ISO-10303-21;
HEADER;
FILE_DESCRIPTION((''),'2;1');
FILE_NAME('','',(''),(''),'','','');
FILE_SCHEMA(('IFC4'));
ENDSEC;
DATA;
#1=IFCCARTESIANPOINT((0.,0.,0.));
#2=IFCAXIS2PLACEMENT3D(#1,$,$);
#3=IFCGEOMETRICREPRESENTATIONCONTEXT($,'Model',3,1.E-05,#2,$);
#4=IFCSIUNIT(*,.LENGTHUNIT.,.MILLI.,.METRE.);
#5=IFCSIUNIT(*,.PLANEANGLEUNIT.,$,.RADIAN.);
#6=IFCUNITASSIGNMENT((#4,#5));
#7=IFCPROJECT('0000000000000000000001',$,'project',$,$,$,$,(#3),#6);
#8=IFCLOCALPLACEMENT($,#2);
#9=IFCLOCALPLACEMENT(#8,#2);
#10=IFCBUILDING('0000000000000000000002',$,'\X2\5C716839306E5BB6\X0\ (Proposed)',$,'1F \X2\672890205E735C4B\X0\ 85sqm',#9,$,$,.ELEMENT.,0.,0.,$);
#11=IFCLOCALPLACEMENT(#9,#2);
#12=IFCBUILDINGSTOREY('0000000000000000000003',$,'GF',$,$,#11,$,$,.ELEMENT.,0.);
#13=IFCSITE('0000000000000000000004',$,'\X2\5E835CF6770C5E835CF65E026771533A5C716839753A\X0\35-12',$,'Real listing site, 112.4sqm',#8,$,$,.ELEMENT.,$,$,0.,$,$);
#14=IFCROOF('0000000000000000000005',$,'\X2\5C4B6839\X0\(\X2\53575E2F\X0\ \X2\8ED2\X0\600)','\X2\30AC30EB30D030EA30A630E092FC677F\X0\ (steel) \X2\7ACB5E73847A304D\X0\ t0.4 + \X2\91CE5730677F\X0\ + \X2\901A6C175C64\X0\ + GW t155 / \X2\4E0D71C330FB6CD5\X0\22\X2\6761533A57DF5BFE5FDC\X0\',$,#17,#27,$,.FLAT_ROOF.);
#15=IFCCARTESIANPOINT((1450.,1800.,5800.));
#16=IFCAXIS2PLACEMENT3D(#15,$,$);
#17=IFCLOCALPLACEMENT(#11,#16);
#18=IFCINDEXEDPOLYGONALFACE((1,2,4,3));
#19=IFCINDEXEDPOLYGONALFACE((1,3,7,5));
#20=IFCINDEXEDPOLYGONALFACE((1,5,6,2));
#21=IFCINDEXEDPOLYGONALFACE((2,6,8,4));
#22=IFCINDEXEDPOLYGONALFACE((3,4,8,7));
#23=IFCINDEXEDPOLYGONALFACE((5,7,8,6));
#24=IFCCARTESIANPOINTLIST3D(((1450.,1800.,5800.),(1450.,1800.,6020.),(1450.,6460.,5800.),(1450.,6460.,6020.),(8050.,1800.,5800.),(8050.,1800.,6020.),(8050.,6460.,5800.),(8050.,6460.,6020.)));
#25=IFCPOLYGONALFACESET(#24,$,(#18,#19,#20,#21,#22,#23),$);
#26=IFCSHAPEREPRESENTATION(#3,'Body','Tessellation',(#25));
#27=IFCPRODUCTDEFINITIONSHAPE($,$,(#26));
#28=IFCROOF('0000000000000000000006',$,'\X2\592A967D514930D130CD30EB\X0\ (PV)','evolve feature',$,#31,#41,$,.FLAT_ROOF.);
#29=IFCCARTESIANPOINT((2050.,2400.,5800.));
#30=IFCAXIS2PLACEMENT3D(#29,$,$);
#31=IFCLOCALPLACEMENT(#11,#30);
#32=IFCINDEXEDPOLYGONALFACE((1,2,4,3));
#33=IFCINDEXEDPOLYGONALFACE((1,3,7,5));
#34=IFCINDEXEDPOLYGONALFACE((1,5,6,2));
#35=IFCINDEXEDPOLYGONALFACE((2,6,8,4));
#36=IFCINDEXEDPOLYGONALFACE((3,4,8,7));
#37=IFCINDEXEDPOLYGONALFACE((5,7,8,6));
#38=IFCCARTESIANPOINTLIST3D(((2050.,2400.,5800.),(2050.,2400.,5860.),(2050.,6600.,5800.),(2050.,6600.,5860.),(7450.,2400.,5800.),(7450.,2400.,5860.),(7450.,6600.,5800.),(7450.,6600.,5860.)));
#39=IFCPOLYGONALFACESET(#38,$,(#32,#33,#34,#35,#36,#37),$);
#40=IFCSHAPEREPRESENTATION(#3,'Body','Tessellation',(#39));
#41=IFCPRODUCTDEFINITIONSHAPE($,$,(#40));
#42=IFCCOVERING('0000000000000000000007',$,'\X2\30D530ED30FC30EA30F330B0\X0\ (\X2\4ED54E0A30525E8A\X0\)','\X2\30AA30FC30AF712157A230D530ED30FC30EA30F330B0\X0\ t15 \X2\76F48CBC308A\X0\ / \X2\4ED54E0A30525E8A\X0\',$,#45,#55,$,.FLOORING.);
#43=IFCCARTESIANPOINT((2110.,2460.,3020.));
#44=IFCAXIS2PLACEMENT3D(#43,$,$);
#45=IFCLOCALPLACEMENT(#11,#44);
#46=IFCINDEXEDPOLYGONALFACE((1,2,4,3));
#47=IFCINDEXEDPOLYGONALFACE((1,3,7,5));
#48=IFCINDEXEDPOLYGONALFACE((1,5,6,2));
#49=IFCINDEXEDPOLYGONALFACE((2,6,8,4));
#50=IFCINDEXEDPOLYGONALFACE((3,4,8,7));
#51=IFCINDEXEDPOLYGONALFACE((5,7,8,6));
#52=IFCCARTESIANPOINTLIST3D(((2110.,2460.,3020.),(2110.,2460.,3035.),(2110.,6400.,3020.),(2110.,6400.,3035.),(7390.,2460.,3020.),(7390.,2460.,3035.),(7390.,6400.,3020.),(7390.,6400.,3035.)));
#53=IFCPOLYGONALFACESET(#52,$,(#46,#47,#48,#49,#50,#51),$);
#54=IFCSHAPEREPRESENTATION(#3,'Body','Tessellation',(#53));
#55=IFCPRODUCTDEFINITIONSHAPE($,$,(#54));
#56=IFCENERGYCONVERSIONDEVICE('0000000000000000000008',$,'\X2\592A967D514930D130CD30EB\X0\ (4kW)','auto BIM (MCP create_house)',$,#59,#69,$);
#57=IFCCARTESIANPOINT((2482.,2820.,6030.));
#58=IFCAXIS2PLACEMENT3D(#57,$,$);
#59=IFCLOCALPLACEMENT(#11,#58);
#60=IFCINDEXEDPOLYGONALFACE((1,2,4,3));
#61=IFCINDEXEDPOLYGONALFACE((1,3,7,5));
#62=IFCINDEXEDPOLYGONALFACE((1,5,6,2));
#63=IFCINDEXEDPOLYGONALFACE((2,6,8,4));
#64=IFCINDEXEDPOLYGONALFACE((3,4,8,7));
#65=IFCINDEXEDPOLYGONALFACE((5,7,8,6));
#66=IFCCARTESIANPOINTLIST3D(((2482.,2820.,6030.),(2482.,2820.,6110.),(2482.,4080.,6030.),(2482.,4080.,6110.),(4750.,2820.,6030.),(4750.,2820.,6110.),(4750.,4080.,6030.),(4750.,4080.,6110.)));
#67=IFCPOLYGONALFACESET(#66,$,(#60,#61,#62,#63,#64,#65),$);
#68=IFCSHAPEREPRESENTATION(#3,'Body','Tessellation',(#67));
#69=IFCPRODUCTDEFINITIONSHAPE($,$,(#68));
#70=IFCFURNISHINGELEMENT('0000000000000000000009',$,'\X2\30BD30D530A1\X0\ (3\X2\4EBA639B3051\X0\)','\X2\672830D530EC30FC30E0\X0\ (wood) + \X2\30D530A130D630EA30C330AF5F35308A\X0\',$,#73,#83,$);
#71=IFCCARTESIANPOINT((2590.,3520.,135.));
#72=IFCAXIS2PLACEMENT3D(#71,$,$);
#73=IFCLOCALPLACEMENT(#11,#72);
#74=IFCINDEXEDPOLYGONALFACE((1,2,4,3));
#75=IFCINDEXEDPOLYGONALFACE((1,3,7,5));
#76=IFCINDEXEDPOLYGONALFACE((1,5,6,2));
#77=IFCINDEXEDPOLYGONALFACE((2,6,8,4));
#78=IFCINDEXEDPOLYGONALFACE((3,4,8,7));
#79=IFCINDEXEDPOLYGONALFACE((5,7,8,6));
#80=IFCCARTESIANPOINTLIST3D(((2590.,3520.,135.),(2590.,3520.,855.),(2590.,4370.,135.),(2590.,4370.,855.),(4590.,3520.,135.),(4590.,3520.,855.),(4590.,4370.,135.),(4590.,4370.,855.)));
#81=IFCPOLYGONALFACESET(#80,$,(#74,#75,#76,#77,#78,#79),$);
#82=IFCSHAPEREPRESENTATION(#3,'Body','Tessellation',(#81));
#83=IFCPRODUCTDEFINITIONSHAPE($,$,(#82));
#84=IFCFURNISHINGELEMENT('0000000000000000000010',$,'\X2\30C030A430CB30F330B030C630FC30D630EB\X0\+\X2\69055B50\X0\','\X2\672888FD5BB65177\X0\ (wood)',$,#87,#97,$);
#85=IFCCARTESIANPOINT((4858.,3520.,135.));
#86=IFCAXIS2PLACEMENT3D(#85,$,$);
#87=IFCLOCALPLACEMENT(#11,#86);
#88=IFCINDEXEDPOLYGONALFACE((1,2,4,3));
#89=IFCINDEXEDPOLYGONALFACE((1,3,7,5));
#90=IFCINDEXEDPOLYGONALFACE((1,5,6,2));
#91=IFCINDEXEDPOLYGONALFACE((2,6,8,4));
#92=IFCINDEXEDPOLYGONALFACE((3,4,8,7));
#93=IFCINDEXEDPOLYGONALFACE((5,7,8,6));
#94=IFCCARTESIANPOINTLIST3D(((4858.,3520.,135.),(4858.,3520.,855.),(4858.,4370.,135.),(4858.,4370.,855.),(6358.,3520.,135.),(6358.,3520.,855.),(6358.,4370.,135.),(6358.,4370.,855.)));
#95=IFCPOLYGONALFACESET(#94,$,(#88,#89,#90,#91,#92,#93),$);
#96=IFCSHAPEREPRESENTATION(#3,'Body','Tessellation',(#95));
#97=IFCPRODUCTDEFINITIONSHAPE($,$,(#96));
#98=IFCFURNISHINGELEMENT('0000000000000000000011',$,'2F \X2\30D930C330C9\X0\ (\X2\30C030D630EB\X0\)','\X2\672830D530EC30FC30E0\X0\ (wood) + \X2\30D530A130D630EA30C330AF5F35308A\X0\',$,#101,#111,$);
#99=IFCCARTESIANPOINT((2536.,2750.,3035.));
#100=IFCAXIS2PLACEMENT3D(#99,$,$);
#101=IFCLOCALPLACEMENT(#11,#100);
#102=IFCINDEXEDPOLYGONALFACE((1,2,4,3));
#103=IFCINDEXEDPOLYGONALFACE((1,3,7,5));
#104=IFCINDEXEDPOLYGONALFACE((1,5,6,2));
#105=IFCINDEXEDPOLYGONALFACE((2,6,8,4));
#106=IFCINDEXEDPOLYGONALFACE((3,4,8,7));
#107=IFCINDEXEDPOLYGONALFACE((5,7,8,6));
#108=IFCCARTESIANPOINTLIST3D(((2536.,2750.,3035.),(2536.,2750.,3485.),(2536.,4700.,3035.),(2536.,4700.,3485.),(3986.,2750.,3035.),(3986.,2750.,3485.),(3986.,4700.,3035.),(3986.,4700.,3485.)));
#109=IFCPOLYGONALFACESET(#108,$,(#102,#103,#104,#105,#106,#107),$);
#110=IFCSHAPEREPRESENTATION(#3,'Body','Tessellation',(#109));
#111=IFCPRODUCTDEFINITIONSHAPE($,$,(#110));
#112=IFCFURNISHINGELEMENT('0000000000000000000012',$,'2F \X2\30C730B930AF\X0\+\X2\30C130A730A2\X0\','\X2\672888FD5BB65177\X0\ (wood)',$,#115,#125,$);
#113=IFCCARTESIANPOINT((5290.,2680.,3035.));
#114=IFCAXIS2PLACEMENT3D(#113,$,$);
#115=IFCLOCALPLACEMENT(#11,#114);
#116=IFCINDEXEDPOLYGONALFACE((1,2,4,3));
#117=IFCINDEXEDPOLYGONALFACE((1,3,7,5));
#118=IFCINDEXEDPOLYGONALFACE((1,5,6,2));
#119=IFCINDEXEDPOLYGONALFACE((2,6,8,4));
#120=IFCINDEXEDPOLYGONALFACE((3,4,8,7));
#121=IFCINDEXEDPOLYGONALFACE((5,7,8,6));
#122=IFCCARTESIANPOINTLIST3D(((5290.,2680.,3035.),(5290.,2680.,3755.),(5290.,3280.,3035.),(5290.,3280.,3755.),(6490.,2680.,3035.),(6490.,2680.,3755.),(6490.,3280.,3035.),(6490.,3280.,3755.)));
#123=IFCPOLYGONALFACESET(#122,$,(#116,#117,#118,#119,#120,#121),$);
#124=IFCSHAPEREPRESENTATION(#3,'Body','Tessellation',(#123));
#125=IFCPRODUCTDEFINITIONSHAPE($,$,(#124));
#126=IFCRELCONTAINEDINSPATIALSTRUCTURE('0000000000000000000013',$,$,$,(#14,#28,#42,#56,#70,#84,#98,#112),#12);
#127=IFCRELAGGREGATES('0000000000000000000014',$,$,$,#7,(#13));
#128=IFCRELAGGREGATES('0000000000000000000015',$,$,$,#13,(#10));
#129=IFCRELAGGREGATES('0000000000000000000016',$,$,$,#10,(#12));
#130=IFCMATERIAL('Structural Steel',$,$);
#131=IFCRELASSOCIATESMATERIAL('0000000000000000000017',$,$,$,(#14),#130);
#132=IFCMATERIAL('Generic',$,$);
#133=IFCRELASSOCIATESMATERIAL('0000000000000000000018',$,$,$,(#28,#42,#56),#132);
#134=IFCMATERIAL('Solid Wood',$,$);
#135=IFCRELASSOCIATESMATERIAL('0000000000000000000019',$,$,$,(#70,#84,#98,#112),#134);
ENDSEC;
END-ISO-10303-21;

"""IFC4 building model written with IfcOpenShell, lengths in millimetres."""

from ifc_helpers import new_model, si_unit, frame, frame_2d, origin, place, context, project, spatial, rectangle, extrude, material, element, save


model = new_model("IFC4")

# Units and contexts
model_context = context("Model", 3, precision=1e-05, world=origin())
ifc_project = project(units=[si_unit("LENGTHUNIT", "METRE", prefix="MILLI"), si_unit("PLANEANGLEUNIT", "RADIAN")], contexts=[model_context])

# Site, building, storey
site_placement = place(None, origin())
site = spatial("IfcSite", under=ifc_project, at=site_placement, Name="広島県広島市東区山根町35-12", ObjectType="Real listing site, 112.4sqm", CompositionType="ELEMENT", RefElevation=0.0)
building_placement = place(site_placement, origin())
building = spatial("IfcBuilding", under=site, at=building_placement, Name="山根の家 (Proposed)", ObjectType="1F 木造平屋 85sqm", CompositionType="ELEMENT", ElevationOfRefHeight=0.0, ElevationOfTerrain=0.0)
storey_placement = place(building_placement, origin())
storey = spatial("IfcBuildingStorey", under=building, at=storey_placement, Name="GF", CompositionType="ELEMENT", Elevation=0.0)

# Shared definitions
ifc_material_1 = material(Name="Solid Wood")

# Shared definitions
ifc_material_2 = material(Name="Generic")

# Roofs
ifc_material_3 = material(Name="Structural Steel")
for number, where, name in (
    (1, (1450.0, 1800.0, 5800.0), "屋根(南帯 軒600)"),
):
    element("IfcRoof", number, at=place(storey_placement, frame(where)), inside=storey, material=ifc_material_3, Name=name, Description="ガルバリウム鋼板 (steel) 立平葺き t0.4 + 野地板 + 通気層 + GW t155 / 不燃・法22条区域対応", PredefinedType="FLAT_ROOF", context=model_context, shape_type="SweptSolid", body=[
        extrude(rectangle(XDim=6600.0, YDim=4660.0, at=frame_2d((3300.0, 2330.0))), frame((1450.0, 1800.0, 5800.0)), (0.0, 0.0, 1.0), 220.0),
    ])
roof_placement = place(storey_placement, frame((2050.0, 2400.0, 5800.0)))
element("IfcRoof", 2, at=roof_placement, inside=storey, material=ifc_material_2, Name="太陽光パネル (PV)", Description="evolve feature", PredefinedType="FLAT_ROOF", context=model_context, shape_type="SweptSolid", body=[
    extrude(rectangle(XDim=5400.0, YDim=4200.0, at=frame_2d((2700.0, 2100.0))), frame((2050.0, 2400.0, 5800.0)), (0.0, 0.0, 1.0), 60.0),
])

# Covering
covering_placement = place(storey_placement, frame((2110.0, 2460.0, 3020.0)))
element("IfcCovering", 3, at=covering_placement, inside=storey, material=ifc_material_2, Name="フローリング (仕上げ床)", Description="オーク無垢フローリング t15 直貼り / 仕上げ床", PredefinedType="FLOORING", context=model_context, shape_type="SweptSolid", body=[
    extrude(rectangle(XDim=5280.0, YDim=3940.0, at=frame_2d((2640.0, 1970.0))), frame((2110.0, 2460.0, 3020.0)), (0.0, 0.0, 1.0), 15.0),
])

# Energy conversion device
energy_conversion_device_placement = place(storey_placement, frame((2482.0, 2820.0, 6030.0)))
element("IfcEnergyConversionDevice", 4, at=energy_conversion_device_placement, inside=storey, material=ifc_material_2, Name="太陽光パネル (4kW)", Description="auto BIM (MCP create_house)", context=model_context, shape_type="SweptSolid", body=[
    extrude(rectangle(XDim=2268.0, YDim=1260.0, at=frame_2d((1134.0, 630.0))), frame((2482.0, 2820.0, 6030.0)), (0.0, 0.0, 1.0), 80.0),
])

# Furnishing elements
furnishing_1_placement = place(storey_placement, frame((2590.0, 3520.0, 135.0)))
element("IfcFurnishingElement", 5, at=furnishing_1_placement, inside=storey, material=ifc_material_1, Name="ソファ (3人掛け)", Description="木フレーム (wood) + ファブリック張り", context=model_context, shape_type="SweptSolid", body=[
    extrude(rectangle(XDim=2000.0, YDim=850.0, at=frame_2d((1000.0, 425.0))), frame((2590.0, 3520.0, 135.0)), (0.0, 0.0, 1.0), 720.0),
])
furnishing_2_placement = place(storey_placement, frame((4858.0, 3520.0, 135.0)))
element("IfcFurnishingElement", 6, at=furnishing_2_placement, inside=storey, material=ifc_material_1, Name="ダイニングテーブル+椅子", Description="木製家具 (wood)", context=model_context, shape_type="SweptSolid", body=[
    extrude(rectangle(XDim=1500.0, YDim=850.0, at=frame_2d((750.0, 425.0))), frame((4858.0, 3520.0, 135.0)), (0.0, 0.0, 1.0), 720.0),
])
furnishing_3_placement = place(storey_placement, frame((2536.0, 2750.0, 3035.0)))
element("IfcFurnishingElement", 7, at=furnishing_3_placement, inside=storey, material=ifc_material_1, Name="2F ベッド (ダブル)", Description="木フレーム (wood) + ファブリック張り", context=model_context, shape_type="SweptSolid", body=[
    extrude(rectangle(XDim=1450.0, YDim=1950.0, at=frame_2d((725.0, 975.0))), frame((2536.0, 2750.0, 3035.0)), (0.0, 0.0, 1.0), 450.0),
])
furnishing_4_placement = place(storey_placement, frame((5290.0, 2680.0, 3035.0)))
element("IfcFurnishingElement", 8, at=furnishing_4_placement, inside=storey, material=ifc_material_1, Name="2F デスク+チェア", Description="木製家具 (wood)", context=model_context, shape_type="SweptSolid", body=[
    extrude(rectangle(XDim=1200.0, YDim=600.0, at=frame_2d((600.0, 300.0))), frame((5290.0, 2680.0, 3035.0)), (0.0, 0.0, 1.0), 720.0),
])

save(model, "model.ifc")
